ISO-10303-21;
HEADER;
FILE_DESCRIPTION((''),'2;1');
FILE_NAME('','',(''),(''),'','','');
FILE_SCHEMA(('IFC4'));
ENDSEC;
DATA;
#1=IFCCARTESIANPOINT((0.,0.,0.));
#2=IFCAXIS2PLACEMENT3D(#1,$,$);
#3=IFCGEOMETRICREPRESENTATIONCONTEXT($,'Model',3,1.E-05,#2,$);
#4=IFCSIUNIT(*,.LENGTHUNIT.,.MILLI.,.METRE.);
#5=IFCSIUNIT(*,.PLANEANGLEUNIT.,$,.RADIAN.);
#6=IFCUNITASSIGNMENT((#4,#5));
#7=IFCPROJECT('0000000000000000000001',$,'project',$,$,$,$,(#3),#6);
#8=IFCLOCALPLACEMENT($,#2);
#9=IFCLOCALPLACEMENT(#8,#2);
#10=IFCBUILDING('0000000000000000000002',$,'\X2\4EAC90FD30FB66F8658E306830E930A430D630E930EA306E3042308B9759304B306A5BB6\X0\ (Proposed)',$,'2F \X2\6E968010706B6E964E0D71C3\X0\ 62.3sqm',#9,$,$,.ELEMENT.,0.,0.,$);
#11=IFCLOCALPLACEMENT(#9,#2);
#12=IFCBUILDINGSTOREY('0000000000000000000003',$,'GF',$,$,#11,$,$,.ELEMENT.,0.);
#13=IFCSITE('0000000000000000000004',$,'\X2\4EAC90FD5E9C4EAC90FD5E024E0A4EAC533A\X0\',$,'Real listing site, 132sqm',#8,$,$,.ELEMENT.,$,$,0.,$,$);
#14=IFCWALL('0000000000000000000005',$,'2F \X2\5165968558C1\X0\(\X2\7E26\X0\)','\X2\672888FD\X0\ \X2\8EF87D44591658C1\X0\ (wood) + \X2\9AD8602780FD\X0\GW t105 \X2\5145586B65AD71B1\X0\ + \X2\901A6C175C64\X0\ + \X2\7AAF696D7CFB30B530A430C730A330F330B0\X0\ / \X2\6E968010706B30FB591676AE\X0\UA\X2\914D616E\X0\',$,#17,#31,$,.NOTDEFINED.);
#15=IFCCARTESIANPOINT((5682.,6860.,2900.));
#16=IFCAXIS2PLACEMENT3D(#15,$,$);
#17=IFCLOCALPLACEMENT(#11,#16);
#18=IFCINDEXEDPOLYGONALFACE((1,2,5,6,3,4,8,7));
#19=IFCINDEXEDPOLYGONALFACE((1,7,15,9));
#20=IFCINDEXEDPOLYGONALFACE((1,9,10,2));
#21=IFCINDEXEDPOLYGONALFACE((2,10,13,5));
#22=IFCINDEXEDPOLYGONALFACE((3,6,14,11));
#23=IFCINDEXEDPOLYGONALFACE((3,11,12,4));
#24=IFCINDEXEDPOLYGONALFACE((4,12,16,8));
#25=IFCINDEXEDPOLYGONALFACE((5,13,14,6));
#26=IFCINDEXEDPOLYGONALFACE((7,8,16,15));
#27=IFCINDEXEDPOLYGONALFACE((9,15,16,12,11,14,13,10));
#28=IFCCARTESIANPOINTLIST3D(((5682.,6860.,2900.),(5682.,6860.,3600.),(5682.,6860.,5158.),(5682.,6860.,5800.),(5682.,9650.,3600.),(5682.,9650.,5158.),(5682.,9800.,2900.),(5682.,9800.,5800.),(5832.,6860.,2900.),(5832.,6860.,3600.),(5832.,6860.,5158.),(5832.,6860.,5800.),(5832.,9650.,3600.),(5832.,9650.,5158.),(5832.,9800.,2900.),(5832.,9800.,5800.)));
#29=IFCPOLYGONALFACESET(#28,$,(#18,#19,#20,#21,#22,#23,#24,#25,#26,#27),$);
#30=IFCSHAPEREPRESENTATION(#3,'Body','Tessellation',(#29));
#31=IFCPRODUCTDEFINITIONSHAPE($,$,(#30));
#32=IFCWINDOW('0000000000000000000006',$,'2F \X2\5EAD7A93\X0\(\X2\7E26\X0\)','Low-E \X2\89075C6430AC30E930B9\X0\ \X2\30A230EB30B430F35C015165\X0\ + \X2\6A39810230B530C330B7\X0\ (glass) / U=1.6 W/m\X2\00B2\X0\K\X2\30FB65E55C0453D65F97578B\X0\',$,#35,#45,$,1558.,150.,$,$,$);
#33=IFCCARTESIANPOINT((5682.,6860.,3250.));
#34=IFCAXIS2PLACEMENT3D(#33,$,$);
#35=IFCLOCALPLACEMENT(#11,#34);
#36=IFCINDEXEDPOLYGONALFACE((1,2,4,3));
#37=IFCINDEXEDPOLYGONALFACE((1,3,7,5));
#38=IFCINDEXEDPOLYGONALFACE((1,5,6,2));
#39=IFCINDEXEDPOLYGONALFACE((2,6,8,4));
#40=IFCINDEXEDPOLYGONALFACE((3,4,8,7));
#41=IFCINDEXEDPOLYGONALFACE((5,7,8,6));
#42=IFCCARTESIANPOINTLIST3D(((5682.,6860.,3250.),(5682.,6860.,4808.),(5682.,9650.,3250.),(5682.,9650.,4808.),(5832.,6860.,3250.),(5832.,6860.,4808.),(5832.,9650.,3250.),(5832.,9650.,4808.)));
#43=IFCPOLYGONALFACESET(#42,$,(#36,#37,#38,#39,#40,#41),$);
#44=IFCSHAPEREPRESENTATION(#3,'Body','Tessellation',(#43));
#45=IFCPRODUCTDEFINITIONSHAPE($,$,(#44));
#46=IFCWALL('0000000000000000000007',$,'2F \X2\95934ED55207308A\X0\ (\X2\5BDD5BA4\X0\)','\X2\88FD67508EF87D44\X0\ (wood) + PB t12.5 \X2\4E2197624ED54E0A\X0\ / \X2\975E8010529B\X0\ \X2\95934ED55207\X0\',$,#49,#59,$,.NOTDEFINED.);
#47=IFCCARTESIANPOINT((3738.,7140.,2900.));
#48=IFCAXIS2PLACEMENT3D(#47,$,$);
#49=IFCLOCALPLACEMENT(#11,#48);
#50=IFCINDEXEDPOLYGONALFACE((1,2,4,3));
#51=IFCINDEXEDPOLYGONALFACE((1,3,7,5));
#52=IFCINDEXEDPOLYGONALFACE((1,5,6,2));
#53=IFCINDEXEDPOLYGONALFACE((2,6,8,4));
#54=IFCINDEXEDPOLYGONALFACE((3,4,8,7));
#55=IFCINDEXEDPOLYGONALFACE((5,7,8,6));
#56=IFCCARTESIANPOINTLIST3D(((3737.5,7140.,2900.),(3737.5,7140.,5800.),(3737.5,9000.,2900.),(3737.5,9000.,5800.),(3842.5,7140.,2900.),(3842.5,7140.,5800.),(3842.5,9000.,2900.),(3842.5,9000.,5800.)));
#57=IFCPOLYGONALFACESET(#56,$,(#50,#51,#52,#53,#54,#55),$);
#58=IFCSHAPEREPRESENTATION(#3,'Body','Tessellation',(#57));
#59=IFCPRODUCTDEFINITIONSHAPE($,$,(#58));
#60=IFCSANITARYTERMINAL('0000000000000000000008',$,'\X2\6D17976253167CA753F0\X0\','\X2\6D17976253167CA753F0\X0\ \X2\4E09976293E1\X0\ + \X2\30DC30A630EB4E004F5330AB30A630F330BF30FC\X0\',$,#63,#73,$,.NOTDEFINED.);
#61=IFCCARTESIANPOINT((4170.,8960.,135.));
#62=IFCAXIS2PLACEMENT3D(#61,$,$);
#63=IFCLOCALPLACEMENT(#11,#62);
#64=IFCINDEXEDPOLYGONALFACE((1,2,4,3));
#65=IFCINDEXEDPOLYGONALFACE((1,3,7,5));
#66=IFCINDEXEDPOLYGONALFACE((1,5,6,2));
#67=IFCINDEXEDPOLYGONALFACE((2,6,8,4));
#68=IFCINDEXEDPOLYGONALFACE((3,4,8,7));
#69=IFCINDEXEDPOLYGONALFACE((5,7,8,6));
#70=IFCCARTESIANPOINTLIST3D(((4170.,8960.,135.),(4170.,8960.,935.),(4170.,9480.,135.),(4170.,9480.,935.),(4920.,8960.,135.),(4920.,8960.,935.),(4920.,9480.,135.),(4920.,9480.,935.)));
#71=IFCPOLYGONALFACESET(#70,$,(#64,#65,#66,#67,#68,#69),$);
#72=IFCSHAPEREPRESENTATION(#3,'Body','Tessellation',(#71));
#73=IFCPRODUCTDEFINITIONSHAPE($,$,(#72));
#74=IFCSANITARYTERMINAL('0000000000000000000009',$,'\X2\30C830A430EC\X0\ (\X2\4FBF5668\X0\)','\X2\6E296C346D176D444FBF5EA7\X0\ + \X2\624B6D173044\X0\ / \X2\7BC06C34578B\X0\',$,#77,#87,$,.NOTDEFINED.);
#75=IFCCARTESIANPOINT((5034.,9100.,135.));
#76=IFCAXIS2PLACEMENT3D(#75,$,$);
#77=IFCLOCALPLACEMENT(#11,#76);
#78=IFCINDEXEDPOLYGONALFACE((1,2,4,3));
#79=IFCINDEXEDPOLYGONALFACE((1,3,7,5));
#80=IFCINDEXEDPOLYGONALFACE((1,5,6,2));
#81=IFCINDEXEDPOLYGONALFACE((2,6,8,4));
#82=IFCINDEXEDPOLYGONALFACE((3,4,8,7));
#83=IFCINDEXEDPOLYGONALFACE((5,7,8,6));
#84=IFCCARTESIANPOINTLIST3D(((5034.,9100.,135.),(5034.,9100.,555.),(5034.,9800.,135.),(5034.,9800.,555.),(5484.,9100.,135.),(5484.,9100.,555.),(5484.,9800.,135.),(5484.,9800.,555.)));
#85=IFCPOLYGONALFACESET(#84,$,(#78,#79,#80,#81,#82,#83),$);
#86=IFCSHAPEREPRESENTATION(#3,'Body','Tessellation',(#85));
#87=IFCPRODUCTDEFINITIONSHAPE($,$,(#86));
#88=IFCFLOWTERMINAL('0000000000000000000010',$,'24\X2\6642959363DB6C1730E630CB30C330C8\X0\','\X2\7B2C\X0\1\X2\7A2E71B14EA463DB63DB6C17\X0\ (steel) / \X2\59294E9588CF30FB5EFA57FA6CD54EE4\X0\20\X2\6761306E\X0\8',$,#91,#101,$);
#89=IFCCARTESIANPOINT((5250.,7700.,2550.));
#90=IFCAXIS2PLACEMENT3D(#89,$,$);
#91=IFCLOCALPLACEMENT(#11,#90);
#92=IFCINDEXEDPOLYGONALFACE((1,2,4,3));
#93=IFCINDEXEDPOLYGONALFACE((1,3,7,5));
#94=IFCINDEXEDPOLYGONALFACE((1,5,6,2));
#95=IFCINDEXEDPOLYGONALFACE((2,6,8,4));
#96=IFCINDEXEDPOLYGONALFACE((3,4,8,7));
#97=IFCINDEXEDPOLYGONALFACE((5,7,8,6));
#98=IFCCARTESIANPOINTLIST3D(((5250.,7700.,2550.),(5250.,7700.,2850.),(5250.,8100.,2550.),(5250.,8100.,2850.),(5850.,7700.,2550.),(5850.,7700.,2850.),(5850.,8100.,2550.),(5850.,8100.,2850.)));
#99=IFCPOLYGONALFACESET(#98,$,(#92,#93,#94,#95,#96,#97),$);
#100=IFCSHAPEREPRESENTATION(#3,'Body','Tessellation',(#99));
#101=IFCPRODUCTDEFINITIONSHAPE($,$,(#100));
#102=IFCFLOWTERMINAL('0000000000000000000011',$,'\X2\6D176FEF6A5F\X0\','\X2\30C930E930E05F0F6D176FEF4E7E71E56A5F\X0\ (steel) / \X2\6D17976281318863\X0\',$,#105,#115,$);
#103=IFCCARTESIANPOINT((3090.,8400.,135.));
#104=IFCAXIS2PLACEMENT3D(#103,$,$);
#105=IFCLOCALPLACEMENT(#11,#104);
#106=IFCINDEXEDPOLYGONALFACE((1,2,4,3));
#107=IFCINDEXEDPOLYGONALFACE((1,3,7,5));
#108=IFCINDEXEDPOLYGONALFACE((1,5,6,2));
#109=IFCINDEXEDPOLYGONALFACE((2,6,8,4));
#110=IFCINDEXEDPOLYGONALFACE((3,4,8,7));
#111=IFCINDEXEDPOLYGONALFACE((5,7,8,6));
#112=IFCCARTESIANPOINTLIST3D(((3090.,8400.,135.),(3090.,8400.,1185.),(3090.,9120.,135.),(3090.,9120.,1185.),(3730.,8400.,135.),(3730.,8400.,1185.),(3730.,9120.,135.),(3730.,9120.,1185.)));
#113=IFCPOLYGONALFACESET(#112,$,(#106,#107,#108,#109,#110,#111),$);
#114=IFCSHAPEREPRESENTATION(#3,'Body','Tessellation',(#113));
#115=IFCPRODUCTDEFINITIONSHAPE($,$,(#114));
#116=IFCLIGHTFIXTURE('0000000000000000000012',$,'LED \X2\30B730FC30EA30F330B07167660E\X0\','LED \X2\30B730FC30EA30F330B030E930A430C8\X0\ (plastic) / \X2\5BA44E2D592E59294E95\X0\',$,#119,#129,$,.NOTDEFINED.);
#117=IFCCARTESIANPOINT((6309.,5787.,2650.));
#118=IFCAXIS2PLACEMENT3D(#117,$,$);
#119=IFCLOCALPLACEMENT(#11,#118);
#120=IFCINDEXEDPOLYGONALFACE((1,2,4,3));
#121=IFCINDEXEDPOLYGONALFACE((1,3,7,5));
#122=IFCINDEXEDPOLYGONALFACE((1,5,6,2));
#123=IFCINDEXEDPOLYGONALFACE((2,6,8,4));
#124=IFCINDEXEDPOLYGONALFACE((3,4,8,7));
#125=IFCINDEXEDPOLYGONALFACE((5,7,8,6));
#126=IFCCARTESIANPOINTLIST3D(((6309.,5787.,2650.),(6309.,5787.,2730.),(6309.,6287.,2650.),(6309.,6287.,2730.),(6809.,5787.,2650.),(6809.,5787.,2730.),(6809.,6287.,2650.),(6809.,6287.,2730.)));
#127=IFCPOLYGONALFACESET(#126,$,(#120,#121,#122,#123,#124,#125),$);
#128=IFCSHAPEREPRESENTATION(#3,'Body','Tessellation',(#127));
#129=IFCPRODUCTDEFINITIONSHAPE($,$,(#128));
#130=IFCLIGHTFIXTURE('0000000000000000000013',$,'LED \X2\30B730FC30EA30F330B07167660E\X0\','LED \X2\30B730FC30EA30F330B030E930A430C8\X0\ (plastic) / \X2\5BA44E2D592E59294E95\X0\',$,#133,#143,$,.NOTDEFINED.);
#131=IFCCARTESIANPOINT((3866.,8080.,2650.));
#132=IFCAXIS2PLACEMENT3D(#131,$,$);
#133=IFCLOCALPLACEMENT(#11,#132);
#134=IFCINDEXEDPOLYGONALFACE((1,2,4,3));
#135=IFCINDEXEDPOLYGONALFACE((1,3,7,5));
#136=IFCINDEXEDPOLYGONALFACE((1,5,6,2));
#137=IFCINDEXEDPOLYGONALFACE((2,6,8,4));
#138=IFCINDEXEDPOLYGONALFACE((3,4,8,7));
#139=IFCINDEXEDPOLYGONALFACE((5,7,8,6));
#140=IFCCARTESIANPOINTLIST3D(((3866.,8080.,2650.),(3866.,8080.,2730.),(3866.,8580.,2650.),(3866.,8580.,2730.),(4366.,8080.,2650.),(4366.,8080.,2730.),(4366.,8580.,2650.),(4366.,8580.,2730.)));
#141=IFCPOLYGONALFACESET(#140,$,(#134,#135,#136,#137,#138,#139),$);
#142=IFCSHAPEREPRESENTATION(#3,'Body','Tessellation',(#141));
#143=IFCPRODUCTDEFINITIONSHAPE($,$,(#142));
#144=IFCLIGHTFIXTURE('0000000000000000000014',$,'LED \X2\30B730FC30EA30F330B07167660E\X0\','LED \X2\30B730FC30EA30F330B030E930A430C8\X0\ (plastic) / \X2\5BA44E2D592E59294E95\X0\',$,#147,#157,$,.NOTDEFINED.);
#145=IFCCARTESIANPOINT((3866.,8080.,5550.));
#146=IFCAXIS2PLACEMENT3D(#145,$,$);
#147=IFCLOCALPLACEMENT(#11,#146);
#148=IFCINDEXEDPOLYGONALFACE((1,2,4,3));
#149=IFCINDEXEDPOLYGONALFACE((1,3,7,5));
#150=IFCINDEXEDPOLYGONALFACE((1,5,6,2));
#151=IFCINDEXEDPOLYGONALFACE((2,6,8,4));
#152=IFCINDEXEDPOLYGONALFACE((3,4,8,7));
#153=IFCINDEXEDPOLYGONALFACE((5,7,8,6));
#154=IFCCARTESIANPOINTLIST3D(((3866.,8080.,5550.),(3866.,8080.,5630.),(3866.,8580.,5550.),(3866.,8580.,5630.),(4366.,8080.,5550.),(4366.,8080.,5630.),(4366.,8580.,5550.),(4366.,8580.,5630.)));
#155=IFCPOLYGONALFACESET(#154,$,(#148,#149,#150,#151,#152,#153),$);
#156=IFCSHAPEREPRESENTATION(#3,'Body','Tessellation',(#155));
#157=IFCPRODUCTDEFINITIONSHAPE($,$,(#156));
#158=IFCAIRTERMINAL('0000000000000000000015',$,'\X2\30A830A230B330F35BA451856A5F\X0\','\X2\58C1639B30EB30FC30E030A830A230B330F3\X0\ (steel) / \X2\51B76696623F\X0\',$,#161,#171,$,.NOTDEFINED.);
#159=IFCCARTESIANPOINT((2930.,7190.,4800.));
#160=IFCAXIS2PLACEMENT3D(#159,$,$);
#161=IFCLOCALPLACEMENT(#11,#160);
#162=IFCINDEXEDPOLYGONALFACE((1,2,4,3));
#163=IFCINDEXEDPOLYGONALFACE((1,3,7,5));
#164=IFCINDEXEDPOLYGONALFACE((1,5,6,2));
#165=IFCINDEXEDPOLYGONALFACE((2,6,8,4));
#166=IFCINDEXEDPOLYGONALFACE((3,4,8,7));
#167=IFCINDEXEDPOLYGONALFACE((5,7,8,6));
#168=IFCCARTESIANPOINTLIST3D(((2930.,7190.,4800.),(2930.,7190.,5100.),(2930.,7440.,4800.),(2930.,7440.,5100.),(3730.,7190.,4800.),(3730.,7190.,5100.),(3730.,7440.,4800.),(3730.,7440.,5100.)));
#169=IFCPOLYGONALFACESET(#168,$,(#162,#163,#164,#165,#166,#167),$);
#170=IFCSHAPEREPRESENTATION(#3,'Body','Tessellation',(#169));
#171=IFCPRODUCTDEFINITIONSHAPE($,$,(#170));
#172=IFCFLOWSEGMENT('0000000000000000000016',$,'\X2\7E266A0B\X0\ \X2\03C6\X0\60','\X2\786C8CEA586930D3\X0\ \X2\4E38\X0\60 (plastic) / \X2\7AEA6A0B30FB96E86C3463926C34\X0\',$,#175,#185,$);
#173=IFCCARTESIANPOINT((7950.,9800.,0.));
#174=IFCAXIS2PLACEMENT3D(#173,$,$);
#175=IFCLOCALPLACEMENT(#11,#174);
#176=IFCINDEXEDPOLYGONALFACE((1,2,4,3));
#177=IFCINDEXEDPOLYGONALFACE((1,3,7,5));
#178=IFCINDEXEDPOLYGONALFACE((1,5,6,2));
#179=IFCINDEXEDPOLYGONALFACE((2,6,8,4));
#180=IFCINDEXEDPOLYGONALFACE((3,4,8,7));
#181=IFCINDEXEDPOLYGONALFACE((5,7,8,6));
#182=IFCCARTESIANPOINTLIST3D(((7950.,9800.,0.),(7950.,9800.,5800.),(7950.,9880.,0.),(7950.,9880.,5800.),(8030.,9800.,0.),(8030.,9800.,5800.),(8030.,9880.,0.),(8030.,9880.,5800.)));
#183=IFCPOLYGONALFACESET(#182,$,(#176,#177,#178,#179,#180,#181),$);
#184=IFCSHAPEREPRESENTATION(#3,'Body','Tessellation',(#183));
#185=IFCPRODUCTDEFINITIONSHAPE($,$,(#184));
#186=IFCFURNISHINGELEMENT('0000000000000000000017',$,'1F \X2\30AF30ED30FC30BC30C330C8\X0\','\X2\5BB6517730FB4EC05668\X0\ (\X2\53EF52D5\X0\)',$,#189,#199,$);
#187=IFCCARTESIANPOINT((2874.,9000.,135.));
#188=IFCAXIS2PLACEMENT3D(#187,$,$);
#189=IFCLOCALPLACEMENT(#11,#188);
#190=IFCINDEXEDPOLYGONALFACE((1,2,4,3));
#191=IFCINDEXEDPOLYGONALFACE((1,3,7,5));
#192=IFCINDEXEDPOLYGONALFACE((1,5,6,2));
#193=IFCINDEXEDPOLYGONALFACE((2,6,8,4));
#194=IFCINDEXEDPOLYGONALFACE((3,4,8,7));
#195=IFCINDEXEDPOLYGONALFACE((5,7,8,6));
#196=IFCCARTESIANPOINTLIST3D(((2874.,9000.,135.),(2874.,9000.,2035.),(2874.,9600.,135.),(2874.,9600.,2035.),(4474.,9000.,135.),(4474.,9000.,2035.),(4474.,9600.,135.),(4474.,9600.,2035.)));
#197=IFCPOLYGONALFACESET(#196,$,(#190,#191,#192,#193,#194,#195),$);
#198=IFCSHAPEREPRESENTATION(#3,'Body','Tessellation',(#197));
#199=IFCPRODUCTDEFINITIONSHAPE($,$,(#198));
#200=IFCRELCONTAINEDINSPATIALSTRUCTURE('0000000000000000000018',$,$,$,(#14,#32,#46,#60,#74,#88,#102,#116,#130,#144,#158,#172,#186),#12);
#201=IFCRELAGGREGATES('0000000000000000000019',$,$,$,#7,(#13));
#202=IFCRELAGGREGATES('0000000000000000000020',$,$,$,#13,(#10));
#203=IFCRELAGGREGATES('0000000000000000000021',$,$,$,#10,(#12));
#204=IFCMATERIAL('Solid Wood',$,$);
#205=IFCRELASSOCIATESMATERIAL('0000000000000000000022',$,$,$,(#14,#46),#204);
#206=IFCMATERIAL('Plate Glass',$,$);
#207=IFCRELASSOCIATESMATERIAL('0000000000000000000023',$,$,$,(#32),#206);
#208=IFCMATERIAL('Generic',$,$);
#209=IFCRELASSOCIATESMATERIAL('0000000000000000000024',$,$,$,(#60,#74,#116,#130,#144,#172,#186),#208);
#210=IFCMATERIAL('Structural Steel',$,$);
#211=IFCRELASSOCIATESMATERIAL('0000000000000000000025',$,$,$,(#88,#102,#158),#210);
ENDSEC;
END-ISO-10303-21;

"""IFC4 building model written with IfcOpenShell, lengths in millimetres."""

from ifc_helpers import new_model, si_unit, frame, frame_2d, origin, place, context, project, spatial, rectangle, extrude, material, element, fill, save


model = new_model("IFC4")

# Units and contexts
model_context = context("Model", 3, precision=1e-05, world=origin())
ifc_project = project(units=[si_unit("LENGTHUNIT", "METRE", prefix="MILLI"), si_unit("PLANEANGLEUNIT", "RADIAN")], contexts=[model_context])

# Site, building, storey
site_placement = place(None, origin())
site = spatial("IfcSite", under=ifc_project, at=site_placement, Name="京都府京都市上京区", ObjectType="Real listing site, 132sqm", CompositionType="ELEMENT", RefElevation=0.0)
building_placement = place(site_placement, origin())
building = spatial("IfcBuilding", under=site, at=building_placement, Name="京都・書斎とライブラリのある静かな家 (Proposed)", ObjectType="2F 準耐火準不燃 62.3sqm", CompositionType="ELEMENT", ElevationOfRefHeight=0.0, ElevationOfTerrain=0.0)
storey_placement = place(building_placement, origin())
storey = spatial("IfcBuildingStorey", under=building, at=storey_placement, Name="GF", CompositionType="ELEMENT", Elevation=0.0)

# Shared definitions
ifc_material_1 = material(Name="Solid Wood")

# Shared definitions
ifc_material_2 = material(Name="Plate Glass")

# Wall, opening, window
wall_1_placement = place(storey_placement, frame((5682.0, 6860.0, 2900.0)))
wall_1 = element("IfcWall", 1, at=wall_1_placement, inside=storey, material=ifc_material_1, Name="2F 入隅壁(縦)", Description="木製 軸組外壁 (wood) + 高性能GW t105 充填断熱 + 通気層 + 窯業系サイディング / 準耐火・外皮UA配慮", PredefinedType="NOTDEFINED", context=model_context, shape_type="SweptSolid", body=[
    extrude(rectangle(XDim=150.0, YDim=2940.0, at=frame_2d((75.0, 1470.0))), frame((5682.0, 6860.0, 2900.0)), (0.0, 0.0, 1.0), 2900.0),
])
opening_1_placement = place(storey_placement, frame((5682.0, 6860.0, 3250.0)))
opening_1 = element("IfcOpeningElement", 2, at=opening_1_placement, cuts=wall_1, PredefinedType="NOTDEFINED", context=model_context, shape_type="SweptSolid", body=[
    extrude(rectangle(XDim=150.0, YDim=2790.0, at=frame_2d((75.0, 1395.0))), frame((5682.0, 6860.0, 3250.0)), (0.0, 0.0, 1.0), 1558.0),
])
window_1_placement = place(storey_placement, frame((5682.0, 6860.0, 3250.0)))
window_1 = element("IfcWindow", 3, at=window_1_placement, inside=storey, material=ifc_material_2, Name="2F 庭窓(縦)", Description="Low-E 複層ガラス アルゴン封入 + 樹脂サッシ (glass) / U=1.6 W/m²K・日射取得型", OverallHeight=1558.0, OverallWidth=150.0, context=model_context, shape_type="SweptSolid", body=[
    extrude(rectangle(XDim=150.0, YDim=2790.0, at=frame_2d((75.0, 1395.0))), frame((5682.0, 6860.0, 3250.0)), (0.0, 0.0, 1.0), 1558.0),
])
fill(opening_1, window_1)

# Wall
wall_2_placement = place(storey_placement, frame((3738.0, 7140.0, 2900.0)))
element("IfcWall", 4, at=wall_2_placement, inside=storey, material=ifc_material_1, Name="2F 間仕切り (寝室)", Description="製材軸組 (wood) + PB t12.5 両面仕上 / 非耐力 間仕切", PredefinedType="NOTDEFINED", context=model_context, shape_type="SweptSolid", body=[
    extrude(rectangle(XDim=105.0, YDim=1860.0, at=frame_2d((52.0, 930.0))), frame((3738.0, 7140.0, 2900.0)), (0.0, 0.0, 1.0), 2900.0),
])

# Sanitary terminals
ifc_material_3 = material(Name="Generic")
sanitary_terminal_1_placement = place(storey_placement, frame((4170.0, 8960.0, 135.0)))
element("IfcSanitaryTerminal", 5, at=sanitary_terminal_1_placement, inside=storey, material=ifc_material_3, Name="洗面化粧台", Description="洗面化粧台 三面鏡 + ボウル一体カウンター", PredefinedType="NOTDEFINED", context=model_context, shape_type="SweptSolid", body=[
    extrude(rectangle(XDim=750.0, YDim=520.0, at=frame_2d((375.0, 260.0))), frame((4170.0, 8960.0, 135.0)), (0.0, 0.0, 1.0), 800.0),
])
sanitary_terminal_2_placement = place(storey_placement, frame((5034.0, 9100.0, 135.0)))
element("IfcSanitaryTerminal", 6, at=sanitary_terminal_2_placement, inside=storey, material=ifc_material_3, Name="トイレ (便器)", Description="温水洗浄便座 + 手洗い / 節水型", PredefinedType="NOTDEFINED", context=model_context, shape_type="SweptSolid", body=[
    extrude(rectangle(XDim=450.0, YDim=700.0, at=frame_2d((225.0, 350.0))), frame((5034.0, 9100.0, 135.0)), (0.0, 0.0, 1.0), 420.0),
])

# Flow terminals
ifc_material_4 = material(Name="Structural Steel")
flow_terminal_1_placement = place(storey_placement, frame((5250.0, 7700.0, 2550.0)))
element("IfcFlowTerminal", 7, at=flow_terminal_1_placement, inside=storey, material=ifc_material_4, Name="24時間換気ユニット", Description="第1種熱交換換気 (steel) / 天井裏・建基法令20条の8", context=model_context, shape_type="SweptSolid", body=[
    extrude(rectangle(XDim=600.0, YDim=400.0, at=frame_2d((300.0, 200.0))), frame((5250.0, 7700.0, 2550.0)), (0.0, 0.0, 1.0), 300.0),
])
flow_terminal_2_placement = place(storey_placement, frame((3090.0, 8400.0, 135.0)))
element("IfcFlowTerminal", 8, at=flow_terminal_2_placement, inside=storey, material=ifc_material_4, Name="洗濯機", Description="ドラム式洗濯乾燥機 (steel) / 洗面脱衣", context=model_context, shape_type="SweptSolid", body=[
    extrude(rectangle(XDim=640.0, YDim=720.0, at=frame_2d((320.0, 360.0))), frame((3090.0, 8400.0, 135.0)), (0.0, 0.0, 1.0), 1050.0),
])

# Light fixtures
light_fixture_1_placement = place(storey_placement, frame((6309.0, 5787.0, 2650.0)))
element("IfcLightFixture", 9, at=light_fixture_1_placement, inside=storey, material=ifc_material_3, Name="LED シーリング照明", Description="LED シーリングライト (plastic) / 室中央天井", PredefinedType="NOTDEFINED", context=model_context, shape_type="SweptSolid", body=[
    extrude(rectangle(XDim=500.0, YDim=500.0, at=frame_2d((250.0, 250.0))), frame((6309.0, 5787.0, 2650.0)), (0.0, 0.0, 1.0), 80.0),
])
light_fixture_2_placement = place(storey_placement, frame((3866.0, 8080.0, 2650.0)))
element("IfcLightFixture", 10, at=light_fixture_2_placement, inside=storey, material=ifc_material_3, Name="LED シーリング照明", Description="LED シーリングライト (plastic) / 室中央天井", PredefinedType="NOTDEFINED", context=model_context, shape_type="SweptSolid", body=[
    extrude(rectangle(XDim=500.0, YDim=500.0, at=frame_2d((250.0, 250.0))), frame((3866.0, 8080.0, 2650.0)), (0.0, 0.0, 1.0), 80.0),
])
light_fixture_3_placement = place(storey_placement, frame((3866.0, 8080.0, 5550.0)))
element("IfcLightFixture", 11, at=light_fixture_3_placement, inside=storey, material=ifc_material_3, Name="LED シーリング照明", Description="LED シーリングライト (plastic) / 室中央天井", PredefinedType="NOTDEFINED", context=model_context, shape_type="SweptSolid", body=[
    extrude(rectangle(XDim=500.0, YDim=500.0, at=frame_2d((250.0, 250.0))), frame((3866.0, 8080.0, 5550.0)), (0.0, 0.0, 1.0), 80.0),
])

# Air terminal
air_terminal_placement = place(storey_placement, frame((2930.0, 7190.0, 4800.0)))
element("IfcAirTerminal", 12, at=air_terminal_placement, inside=storey, material=ifc_material_4, Name="エアコン室内機", Description="壁掛ルームエアコン (steel) / 冷暖房", PredefinedType="NOTDEFINED", context=model_context, shape_type="SweptSolid", body=[
    extrude(rectangle(XDim=800.0, YDim=250.0, at=frame_2d((400.0, 125.0))), frame((2930.0, 7190.0, 4800.0)), (0.0, 0.0, 1.0), 300.0),
])

# Flow segment
flow_segment_placement = place(storey_placement, frame((7950.0, 9800.0, 0.0)))
element("IfcFlowSegment", 13, at=flow_segment_placement, inside=storey, material=ifc_material_3, Name="縦樋 φ60", Description="硬質塩ビ 丸60 (plastic) / 竪樋・雨水排水", context=model_context, shape_type="SweptSolid", body=[
    extrude(rectangle(XDim=80.0, YDim=80.0, at=frame_2d((40.0, 40.0))), frame((7950.0, 9800.0, 0.0)), (0.0, 0.0, 1.0), 5800.0),
])

# Furnishing element
furnishing_1_placement = place(storey_placement, frame((2874.0, 9000.0, 135.0)))
element("IfcFurnishingElement", 14, at=furnishing_1_placement, inside=storey, material=ifc_material_3, Name="1F クローゼット", Description="家具・什器 (可動)", context=model_context, shape_type="SweptSolid", body=[
    extrude(rectangle(XDim=1600.0, YDim=600.0, at=frame_2d((800.0, 300.0))), frame((2874.0, 9000.0, 135.0)), (0.0, 0.0, 1.0), 1900.0),
])

save(model, "model.ifc")
